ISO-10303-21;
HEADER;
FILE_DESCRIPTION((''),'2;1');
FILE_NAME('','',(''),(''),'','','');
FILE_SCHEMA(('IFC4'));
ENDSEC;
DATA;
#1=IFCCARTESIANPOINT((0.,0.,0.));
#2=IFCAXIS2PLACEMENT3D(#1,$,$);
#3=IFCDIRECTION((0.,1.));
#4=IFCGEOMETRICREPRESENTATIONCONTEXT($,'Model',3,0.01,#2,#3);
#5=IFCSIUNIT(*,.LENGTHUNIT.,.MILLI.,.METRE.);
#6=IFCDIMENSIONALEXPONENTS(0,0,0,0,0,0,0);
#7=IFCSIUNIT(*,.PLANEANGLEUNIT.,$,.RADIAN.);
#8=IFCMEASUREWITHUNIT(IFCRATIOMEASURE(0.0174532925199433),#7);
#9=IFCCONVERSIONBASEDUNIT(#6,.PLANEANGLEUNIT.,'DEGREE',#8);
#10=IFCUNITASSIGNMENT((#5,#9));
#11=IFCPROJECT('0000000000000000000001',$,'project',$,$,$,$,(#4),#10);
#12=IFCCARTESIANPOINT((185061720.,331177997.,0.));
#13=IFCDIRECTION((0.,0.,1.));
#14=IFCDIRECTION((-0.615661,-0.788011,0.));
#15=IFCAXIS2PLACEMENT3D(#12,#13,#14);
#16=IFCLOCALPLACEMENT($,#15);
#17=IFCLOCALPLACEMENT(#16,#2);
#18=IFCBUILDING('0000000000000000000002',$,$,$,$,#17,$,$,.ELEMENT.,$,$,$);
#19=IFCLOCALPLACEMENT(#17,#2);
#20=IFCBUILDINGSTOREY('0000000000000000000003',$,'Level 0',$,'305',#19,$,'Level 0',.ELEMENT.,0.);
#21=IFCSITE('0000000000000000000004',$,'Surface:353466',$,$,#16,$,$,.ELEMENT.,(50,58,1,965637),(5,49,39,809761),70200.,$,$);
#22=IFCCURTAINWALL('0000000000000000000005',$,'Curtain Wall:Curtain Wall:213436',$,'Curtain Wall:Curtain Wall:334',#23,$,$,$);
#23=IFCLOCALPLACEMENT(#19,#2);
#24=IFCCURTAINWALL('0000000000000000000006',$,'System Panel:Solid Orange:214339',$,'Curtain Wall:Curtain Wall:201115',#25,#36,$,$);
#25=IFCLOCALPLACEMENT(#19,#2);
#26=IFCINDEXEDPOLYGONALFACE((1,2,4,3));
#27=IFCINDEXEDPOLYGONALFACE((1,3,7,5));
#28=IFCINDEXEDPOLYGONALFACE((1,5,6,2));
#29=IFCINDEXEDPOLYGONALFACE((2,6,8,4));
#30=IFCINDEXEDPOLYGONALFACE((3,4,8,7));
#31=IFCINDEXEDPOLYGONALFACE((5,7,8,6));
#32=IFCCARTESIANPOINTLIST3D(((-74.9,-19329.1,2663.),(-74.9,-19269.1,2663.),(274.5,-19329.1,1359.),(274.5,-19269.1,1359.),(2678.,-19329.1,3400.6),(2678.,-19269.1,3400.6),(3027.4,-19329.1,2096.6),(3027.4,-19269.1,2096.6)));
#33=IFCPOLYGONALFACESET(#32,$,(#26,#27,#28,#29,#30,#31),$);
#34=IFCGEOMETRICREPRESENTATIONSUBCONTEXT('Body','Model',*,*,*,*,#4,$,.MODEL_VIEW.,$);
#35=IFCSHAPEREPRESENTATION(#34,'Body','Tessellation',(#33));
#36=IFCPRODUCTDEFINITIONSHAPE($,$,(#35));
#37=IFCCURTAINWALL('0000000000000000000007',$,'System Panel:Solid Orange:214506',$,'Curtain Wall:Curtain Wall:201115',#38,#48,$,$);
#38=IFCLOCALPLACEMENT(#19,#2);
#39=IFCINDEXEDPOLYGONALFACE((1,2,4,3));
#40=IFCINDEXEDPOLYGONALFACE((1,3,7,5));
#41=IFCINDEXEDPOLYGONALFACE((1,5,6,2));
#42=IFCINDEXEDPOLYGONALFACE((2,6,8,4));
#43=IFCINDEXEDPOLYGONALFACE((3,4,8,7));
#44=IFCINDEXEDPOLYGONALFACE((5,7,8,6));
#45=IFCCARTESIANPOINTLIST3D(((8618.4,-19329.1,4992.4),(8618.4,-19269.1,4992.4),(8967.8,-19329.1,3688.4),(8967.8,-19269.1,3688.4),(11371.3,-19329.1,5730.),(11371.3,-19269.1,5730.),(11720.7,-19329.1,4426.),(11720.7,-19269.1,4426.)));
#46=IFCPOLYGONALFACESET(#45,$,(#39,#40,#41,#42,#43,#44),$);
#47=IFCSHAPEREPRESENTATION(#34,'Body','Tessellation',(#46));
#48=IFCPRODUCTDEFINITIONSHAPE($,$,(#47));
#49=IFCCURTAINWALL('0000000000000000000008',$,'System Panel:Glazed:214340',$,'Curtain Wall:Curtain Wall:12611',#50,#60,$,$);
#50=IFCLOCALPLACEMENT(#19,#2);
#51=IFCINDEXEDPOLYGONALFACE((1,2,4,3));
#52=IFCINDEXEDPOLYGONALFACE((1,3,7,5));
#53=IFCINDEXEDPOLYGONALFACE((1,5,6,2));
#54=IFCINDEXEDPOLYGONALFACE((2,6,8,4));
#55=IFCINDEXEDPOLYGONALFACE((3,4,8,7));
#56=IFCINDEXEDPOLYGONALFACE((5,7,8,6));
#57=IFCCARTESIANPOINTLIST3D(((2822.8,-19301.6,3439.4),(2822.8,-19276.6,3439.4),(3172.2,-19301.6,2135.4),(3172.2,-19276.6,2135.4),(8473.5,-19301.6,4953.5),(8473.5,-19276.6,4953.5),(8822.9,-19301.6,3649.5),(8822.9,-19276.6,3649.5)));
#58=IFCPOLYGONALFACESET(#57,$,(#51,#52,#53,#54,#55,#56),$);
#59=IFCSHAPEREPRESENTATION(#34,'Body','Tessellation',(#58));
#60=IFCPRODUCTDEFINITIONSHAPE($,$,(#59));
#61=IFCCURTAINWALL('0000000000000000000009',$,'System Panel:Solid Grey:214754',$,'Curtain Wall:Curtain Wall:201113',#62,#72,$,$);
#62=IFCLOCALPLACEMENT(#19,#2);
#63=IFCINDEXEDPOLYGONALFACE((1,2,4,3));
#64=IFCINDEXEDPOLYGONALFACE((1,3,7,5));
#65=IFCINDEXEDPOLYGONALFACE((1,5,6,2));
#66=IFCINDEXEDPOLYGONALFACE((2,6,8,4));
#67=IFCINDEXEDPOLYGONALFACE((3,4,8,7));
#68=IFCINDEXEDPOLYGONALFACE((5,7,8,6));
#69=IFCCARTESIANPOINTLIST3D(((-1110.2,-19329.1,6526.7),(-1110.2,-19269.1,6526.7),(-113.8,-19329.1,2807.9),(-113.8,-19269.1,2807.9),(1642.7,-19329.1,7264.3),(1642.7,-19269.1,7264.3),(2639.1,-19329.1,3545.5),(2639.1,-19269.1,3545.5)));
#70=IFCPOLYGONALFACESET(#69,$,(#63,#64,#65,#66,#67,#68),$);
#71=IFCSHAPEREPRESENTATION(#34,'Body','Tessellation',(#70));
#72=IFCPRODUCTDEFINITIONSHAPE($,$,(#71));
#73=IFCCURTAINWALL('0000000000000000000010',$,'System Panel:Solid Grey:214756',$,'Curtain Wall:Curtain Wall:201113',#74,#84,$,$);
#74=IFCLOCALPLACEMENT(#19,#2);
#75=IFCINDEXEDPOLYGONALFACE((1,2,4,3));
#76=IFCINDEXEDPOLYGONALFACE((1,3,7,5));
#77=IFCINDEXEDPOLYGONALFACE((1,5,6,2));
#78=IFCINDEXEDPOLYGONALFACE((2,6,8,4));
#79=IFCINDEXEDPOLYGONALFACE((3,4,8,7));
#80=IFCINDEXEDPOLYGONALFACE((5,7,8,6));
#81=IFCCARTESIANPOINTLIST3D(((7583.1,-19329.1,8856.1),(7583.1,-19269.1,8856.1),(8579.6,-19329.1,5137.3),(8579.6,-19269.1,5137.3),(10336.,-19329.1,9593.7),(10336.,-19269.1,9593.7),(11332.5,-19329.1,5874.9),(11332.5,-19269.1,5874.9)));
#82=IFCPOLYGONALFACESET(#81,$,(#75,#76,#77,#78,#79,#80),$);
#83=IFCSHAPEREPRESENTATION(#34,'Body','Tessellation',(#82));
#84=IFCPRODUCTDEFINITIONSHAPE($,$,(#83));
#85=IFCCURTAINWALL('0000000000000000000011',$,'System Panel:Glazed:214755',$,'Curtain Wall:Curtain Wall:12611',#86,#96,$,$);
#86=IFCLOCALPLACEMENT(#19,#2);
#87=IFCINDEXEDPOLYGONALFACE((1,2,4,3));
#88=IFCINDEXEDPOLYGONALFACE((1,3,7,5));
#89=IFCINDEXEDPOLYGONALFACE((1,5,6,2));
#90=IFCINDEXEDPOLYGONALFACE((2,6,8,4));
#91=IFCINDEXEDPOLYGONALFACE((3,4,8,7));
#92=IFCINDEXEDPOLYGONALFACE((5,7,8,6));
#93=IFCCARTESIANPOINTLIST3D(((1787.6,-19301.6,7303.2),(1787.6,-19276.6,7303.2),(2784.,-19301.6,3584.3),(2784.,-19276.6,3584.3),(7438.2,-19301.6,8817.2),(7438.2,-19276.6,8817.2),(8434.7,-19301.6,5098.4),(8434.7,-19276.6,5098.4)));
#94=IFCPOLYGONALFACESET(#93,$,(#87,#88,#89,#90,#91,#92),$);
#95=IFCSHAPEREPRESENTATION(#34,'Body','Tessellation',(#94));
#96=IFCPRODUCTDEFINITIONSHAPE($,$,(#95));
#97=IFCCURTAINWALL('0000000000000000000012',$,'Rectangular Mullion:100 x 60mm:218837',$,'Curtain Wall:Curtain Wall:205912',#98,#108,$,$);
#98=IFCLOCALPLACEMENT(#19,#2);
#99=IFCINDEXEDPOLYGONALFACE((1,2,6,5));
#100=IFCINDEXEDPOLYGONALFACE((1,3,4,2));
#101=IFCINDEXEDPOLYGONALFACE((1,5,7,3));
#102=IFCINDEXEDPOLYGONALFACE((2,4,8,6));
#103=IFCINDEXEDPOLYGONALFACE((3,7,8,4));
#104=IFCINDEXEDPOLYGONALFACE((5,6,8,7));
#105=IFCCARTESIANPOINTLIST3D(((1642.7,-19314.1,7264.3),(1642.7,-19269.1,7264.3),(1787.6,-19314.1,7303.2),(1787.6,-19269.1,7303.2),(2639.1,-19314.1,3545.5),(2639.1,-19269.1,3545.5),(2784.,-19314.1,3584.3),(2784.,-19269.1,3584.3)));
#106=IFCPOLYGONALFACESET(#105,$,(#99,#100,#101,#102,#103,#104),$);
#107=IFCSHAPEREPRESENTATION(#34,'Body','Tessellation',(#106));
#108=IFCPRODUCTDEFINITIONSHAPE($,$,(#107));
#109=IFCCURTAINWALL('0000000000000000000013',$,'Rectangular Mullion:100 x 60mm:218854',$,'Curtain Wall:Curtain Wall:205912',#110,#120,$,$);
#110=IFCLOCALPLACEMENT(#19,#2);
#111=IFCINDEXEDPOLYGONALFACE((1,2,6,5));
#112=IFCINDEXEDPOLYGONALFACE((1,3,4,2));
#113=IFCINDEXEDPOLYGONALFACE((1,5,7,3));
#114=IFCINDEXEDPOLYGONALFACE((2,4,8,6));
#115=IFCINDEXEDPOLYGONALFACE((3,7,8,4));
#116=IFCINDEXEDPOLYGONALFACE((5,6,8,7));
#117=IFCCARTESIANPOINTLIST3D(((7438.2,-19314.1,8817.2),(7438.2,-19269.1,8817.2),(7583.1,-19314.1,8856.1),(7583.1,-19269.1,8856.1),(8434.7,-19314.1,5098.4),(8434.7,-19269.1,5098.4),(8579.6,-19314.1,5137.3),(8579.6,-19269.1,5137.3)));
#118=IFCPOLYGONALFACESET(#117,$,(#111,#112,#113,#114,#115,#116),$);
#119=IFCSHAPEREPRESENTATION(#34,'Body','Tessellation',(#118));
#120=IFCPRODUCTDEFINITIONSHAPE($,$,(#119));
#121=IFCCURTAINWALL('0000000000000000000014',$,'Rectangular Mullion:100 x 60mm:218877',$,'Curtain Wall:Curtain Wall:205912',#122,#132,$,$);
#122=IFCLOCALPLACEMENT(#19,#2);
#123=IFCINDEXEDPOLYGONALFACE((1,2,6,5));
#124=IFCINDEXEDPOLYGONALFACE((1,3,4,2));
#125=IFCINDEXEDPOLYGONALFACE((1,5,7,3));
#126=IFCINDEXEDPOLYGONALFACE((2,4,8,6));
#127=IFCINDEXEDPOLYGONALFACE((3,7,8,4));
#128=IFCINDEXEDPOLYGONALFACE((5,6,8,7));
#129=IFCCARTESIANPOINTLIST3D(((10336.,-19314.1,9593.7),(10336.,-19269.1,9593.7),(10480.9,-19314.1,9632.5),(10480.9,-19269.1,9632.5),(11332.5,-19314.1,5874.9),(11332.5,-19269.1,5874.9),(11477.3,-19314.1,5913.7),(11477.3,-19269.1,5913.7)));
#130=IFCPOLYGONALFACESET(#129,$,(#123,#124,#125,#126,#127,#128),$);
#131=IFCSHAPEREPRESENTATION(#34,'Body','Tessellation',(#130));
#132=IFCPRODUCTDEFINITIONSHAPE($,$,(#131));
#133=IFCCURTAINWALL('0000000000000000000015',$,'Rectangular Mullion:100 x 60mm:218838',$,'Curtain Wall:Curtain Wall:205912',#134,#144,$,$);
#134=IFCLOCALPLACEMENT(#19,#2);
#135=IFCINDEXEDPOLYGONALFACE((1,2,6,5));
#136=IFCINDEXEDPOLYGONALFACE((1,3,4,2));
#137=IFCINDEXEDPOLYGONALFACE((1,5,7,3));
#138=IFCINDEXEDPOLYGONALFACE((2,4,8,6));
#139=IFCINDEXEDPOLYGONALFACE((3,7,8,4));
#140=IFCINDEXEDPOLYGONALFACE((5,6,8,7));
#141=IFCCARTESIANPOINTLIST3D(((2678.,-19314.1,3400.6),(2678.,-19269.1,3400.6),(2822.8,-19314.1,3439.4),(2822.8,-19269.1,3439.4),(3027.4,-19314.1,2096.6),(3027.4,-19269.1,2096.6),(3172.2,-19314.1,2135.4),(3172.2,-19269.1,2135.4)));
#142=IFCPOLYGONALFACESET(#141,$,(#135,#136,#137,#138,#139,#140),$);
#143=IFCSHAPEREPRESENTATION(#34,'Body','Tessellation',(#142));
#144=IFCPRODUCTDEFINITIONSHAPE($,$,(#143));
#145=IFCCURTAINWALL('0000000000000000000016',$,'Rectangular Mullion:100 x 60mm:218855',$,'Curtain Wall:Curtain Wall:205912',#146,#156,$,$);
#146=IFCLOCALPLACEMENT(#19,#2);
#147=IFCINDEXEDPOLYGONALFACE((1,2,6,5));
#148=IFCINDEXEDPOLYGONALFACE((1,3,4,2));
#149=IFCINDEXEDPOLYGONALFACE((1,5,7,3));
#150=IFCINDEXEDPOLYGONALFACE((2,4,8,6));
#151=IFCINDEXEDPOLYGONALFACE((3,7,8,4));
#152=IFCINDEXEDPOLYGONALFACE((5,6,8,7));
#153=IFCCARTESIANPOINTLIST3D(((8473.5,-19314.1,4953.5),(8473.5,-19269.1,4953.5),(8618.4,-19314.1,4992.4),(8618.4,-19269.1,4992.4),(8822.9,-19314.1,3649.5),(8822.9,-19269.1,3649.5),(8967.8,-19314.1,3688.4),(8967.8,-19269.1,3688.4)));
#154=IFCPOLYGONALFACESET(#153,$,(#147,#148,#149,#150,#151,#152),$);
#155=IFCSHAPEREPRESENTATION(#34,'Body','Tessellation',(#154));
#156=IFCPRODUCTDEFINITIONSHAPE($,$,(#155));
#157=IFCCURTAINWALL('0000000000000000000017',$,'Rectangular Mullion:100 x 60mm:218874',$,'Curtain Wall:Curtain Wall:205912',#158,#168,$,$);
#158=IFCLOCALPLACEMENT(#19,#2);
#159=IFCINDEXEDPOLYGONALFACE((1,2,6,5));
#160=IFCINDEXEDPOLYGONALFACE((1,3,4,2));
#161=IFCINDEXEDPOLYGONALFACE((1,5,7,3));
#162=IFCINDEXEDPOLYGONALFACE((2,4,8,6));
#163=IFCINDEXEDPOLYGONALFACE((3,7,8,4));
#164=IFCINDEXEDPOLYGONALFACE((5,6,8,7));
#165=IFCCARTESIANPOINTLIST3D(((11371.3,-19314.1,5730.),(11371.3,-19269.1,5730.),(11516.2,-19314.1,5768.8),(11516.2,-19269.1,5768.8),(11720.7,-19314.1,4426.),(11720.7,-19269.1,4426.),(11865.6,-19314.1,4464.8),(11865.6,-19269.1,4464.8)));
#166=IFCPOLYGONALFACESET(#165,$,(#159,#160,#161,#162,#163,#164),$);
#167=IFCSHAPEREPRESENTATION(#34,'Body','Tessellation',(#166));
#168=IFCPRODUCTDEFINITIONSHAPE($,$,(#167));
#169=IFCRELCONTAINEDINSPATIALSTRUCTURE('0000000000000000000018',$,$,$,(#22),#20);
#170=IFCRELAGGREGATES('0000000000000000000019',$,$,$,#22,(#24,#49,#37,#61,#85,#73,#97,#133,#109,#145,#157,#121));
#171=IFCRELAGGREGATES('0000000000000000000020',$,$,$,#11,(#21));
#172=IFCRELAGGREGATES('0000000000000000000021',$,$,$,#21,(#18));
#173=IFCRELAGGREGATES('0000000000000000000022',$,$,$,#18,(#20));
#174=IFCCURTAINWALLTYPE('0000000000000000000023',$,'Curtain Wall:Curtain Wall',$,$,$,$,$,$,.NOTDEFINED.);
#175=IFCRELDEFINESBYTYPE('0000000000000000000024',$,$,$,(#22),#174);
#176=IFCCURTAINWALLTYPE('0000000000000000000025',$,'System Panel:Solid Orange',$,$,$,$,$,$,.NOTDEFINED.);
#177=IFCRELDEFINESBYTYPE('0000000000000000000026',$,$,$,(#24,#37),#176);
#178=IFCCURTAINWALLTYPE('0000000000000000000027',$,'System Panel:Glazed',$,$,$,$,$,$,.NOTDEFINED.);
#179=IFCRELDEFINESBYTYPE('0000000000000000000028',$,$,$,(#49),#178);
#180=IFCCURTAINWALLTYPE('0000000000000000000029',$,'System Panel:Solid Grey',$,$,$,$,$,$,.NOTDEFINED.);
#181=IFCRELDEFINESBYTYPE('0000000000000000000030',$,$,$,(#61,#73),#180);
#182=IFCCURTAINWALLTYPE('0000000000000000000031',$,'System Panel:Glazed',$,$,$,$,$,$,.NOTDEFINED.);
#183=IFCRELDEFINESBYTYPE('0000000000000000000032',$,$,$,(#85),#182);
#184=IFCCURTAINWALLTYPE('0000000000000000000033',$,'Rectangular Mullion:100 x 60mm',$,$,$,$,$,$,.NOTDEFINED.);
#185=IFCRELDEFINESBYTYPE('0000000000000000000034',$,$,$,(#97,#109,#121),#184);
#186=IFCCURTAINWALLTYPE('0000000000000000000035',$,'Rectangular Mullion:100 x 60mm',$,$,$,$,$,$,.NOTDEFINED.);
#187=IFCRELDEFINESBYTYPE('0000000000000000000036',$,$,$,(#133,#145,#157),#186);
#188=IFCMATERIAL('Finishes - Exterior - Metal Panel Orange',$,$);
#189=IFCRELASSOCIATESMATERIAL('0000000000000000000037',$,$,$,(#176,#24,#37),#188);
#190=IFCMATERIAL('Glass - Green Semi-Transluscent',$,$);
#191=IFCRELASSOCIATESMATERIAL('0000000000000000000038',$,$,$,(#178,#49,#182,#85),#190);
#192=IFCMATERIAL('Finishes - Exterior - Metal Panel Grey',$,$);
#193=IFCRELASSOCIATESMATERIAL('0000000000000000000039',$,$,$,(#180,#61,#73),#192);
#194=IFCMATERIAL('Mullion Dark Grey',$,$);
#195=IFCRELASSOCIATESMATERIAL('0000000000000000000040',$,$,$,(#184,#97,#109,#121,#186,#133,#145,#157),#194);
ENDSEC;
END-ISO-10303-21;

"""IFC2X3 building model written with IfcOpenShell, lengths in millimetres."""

from ifc_helpers import new_model, entity, si_unit, converted_unit, direction, frame, frame_2d, origin, origin_2d_with_axis, place, context, subcontext, project, spatial, rectangle, extrude, source, transform, mapped, material, type_object, type_shapes, element, aggregate, save


model = new_model("IFC2X3")

# Units and contexts
model_context = context("Model", 3, precision=0.01, world=origin(), true_north=direction((0.0, 1.0)))
body_context = subcontext(model_context, "Body", "Model", "MODEL_VIEW")
ifc_project = project(units=[si_unit("LENGTHUNIT", "METRE", prefix="MILLI"), converted_unit("PLANEANGLEUNIT", "DEGREE", entity("IfcRatioMeasure", 0.0174532925199433), si_unit("PLANEANGLEUNIT", "RADIAN"), dimensions=[0, 0, 0, 0, 0, 0, 0])], contexts=[model_context])

# Site, building, storey
site_placement = place(None, frame((185061720.0, 331177997.0, 0.0), z_axis=(0.0, 0.0, 1.0), x_axis=(-0.615661, -0.788011, 0.0)))
site = spatial("IfcSite", under=ifc_project, at=site_placement, Name="Surface:353466", CompositionType="ELEMENT", RefLatitude=(50, 58, 1, 965637), RefLongitude=(5, 49, 39, 809761), RefElevation=70200.0)
building_placement = place(site_placement, origin())
building = spatial("IfcBuilding", under=site, at=building_placement, CompositionType="ELEMENT")
storey_placement = place(building_placement, origin())
storey = spatial("IfcBuildingStorey", under=building, at=storey_placement, Name="Level 0", ObjectType="305", LongName="Level 0", CompositionType="ELEMENT", Elevation=0.0)

# Curtain walls
curtain_wall_type_1 = type_object("IfcCurtainWallType", Name="Curtain Wall:Curtain Wall", PredefinedType="NOTDEFINED")
curtain_wall_1_placement = place(storey_placement, origin())
curtain_wall_1 = element("IfcCurtainWall", 1, at=curtain_wall_1_placement, inside=storey, type_object=curtain_wall_type_1, Name="Curtain Wall:Curtain Wall:213436", ObjectType="Curtain Wall:Curtain Wall:334")
ifc_material_1 = material(Name="Finishes - Exterior - Metal Panel Grey")
ifc_material_2 = material(Name="Finishes - Exterior - Metal Panel Orange")
curtain_wall_type_2 = type_object("IfcCurtainWallType", Name="System Panel:Solid Orange", PredefinedType="NOTDEFINED", material=ifc_material_2)
shared_shape_1 = source(origin(), body_context, "Body", "SweptSolid", [
    extrude(rectangle(XDim=60.0, YDim=2850.0, at=frame_2d((0.0, 0.0), x_axis=(1.0, 0.0))), frame((0.0, 0.0, 0.0), z_axis=(0.0, 0.0, 1.0), x_axis=(0.0, 1.0, 0.0)), (0.0, 0.0, 1.0), 1350.0),
])
type_shapes(curtain_wall_type_2, [shared_shape_1])
curtain_wall_2_placement = place(storey_placement, frame((1650.9, -19299.1, 1727.8), z_axis=(-0.258819, 0.0, 0.965926), x_axis=(0.965926, 0.0, 0.258819)))
curtain_wall_2 = element("IfcCurtainWall", 2, at=curtain_wall_2_placement, type_object=curtain_wall_type_2, material=ifc_material_2, Name="System Panel:Solid Orange:214339", ObjectType="Curtain Wall:Curtain Wall:201115", context=body_context, shape_type="MappedRepresentation", body=[
    mapped(shared_shape_1, transform((0.0, 0.0, 0.0), scale=1.0)),
])
curtain_wall_3_placement = place(storey_placement, frame((10344.2, -19299.1, 4057.2), z_axis=(-0.258819, 0.0, 0.965926), x_axis=(0.965926, 0.0, 0.258819)))
curtain_wall_3 = element("IfcCurtainWall", 3, at=curtain_wall_3_placement, type_object=curtain_wall_type_2, material=ifc_material_2, Name="System Panel:Solid Orange:214506", ObjectType="Curtain Wall:Curtain Wall:201115", context=body_context, shape_type="MappedRepresentation", body=[
    mapped(shared_shape_1, transform((0.0, 0.0, 0.0), scale=1.0)),
])
ifc_material_3 = material(Name="Glass - Green Semi-Transluscent")
curtain_wall_type_3 = type_object("IfcCurtainWallType", Name="System Panel:Glazed", PredefinedType="NOTDEFINED", material=ifc_material_3)
shared_shape_2 = source(origin(), body_context, "Body", "SweptSolid", [
    extrude(rectangle(XDim=25.0, YDim=5850.0, at=origin_2d_with_axis()), frame((0.0, 10.0, 0.0), z_axis=(0.0, 0.0, 1.0), x_axis=(0.0, 1.0, 0.0)), (0.0, 0.0, 1.0), 1350.0),
])
type_shapes(curtain_wall_type_3, [shared_shape_2])
curtain_wall_4_placement = place(storey_placement, frame((5997.6, -19299.1, 2892.5), z_axis=(-0.258819, 0.0, 0.965926), x_axis=(0.965926, 0.0, 0.258819)))
curtain_wall_4 = element("IfcCurtainWall", 4, at=curtain_wall_4_placement, type_object=curtain_wall_type_3, material=ifc_material_3, Name="System Panel:Glazed:214340", ObjectType="Curtain Wall:Curtain Wall:12611", context=body_context, shape_type="MappedRepresentation", body=[
    mapped(shared_shape_2, transform((0.0, 0.0, 0.0), scale=1.0)),
])
curtain_wall_type_4 = type_object("IfcCurtainWallType", Name="System Panel:Solid Grey", PredefinedType="NOTDEFINED", material=ifc_material_1)
shared_shape_3 = source(origin(), body_context, "Body", "SweptSolid", [
    extrude(rectangle(XDim=60.0, YDim=2850.0, at=origin_2d_with_axis()), frame((0.0, 0.0, 0.0), z_axis=(0.0, 0.0, 1.0), x_axis=(0.0, 1.0, 0.0)), (0.0, 0.0, 1.0), 3850.0),
])
type_shapes(curtain_wall_type_4, [shared_shape_3])
curtain_wall_5_placement = place(storey_placement, frame((1262.7, -19299.1, 3176.7), z_axis=(-0.258819, 0.0, 0.965926), x_axis=(0.965926, 0.0, 0.258819)))
curtain_wall_5 = element("IfcCurtainWall", 5, at=curtain_wall_5_placement, type_object=curtain_wall_type_4, material=ifc_material_1, Name="System Panel:Solid Grey:214754", ObjectType="Curtain Wall:Curtain Wall:201113", context=body_context, shape_type="MappedRepresentation", body=[
    mapped(shared_shape_3, transform((0.0, 0.0, 0.0), scale=1.0)),
])
curtain_wall_6_placement = place(storey_placement, frame((9956.0, -19299.1, 5506.1), z_axis=(-0.258819, 0.0, 0.965926), x_axis=(0.965926, 0.0, 0.258819)))
curtain_wall_6 = element("IfcCurtainWall", 6, at=curtain_wall_6_placement, type_object=curtain_wall_type_4, material=ifc_material_1, Name="System Panel:Solid Grey:214756", ObjectType="Curtain Wall:Curtain Wall:201113", context=body_context, shape_type="MappedRepresentation", body=[
    mapped(shared_shape_3, transform((0.0, 0.0, 0.0), scale=1.0)),
])
curtain_wall_type_5 = type_object("IfcCurtainWallType", Name="System Panel:Glazed", PredefinedType="NOTDEFINED", material=ifc_material_3)
shared_shape_4 = source(origin(), body_context, "Body", "SweptSolid", [
    extrude(rectangle(XDim=25.0, YDim=5850.0, at=origin_2d_with_axis()), frame((0.0, 10.0, 0.0), z_axis=(0.0, 0.0, 1.0), x_axis=(0.0, 1.0, 0.0)), (0.0, 0.0, 1.0), 3850.0),
])
type_shapes(curtain_wall_type_5, [shared_shape_4])
curtain_wall_7_placement = place(storey_placement, frame((5609.3, -19299.1, 4341.4), z_axis=(-0.258819, 0.0, 0.965926), x_axis=(0.965926, 0.0, 0.258819)))
curtain_wall_7 = element("IfcCurtainWall", 7, at=curtain_wall_7_placement, type_object=curtain_wall_type_5, material=ifc_material_3, Name="System Panel:Glazed:214755", ObjectType="Curtain Wall:Curtain Wall:12611", context=body_context, shape_type="MappedRepresentation", body=[
    mapped(shared_shape_4, transform((0.0, 0.0, 0.0), scale=1.0)),
])
ifc_material_4 = material(Name="Mullion Dark Grey")
curtain_wall_type_6 = type_object("IfcCurtainWallType", Name="Rectangular Mullion:100 x 60mm", PredefinedType="NOTDEFINED", material=ifc_material_4)
shared_shape_5 = source(origin(), body_context, "Body", "SweptSolid", [
    extrude(rectangle(XDim=150.0, YDim=45.0, at=frame_2d((0.0, 0.0), x_axis=(1.0, 0.0))), frame((0.0, -7.5, -3850.0)), (0.0, 0.0, 1.0), 3850.0),
])
type_shapes(curtain_wall_type_6, [shared_shape_5])
curtain_wall_8_placement = place(storey_placement, frame((2711.6, -19299.1, 3564.9), z_axis=(0.258819, 0.0, -0.965926), x_axis=(0.965926, 0.0, 0.258819)))
curtain_wall_8 = element("IfcCurtainWall", 8, at=curtain_wall_8_placement, type_object=curtain_wall_type_6, material=ifc_material_4, Name="Rectangular Mullion:100 x 60mm:218837", ObjectType="Curtain Wall:Curtain Wall:205912", context=body_context, shape_type="MappedRepresentation", body=[
    mapped(shared_shape_5, transform((0.0, 0.0, 0.0), scale=1.0)),
])
curtain_wall_9_placement = place(storey_placement, frame((8507.1, -19299.1, 5117.8), z_axis=(0.258819, 0.0, -0.965926), x_axis=(0.965926, 0.0, 0.258819)))
curtain_wall_9 = element("IfcCurtainWall", 9, at=curtain_wall_9_placement, type_object=curtain_wall_type_6, material=ifc_material_4, Name="Rectangular Mullion:100 x 60mm:218854", ObjectType="Curtain Wall:Curtain Wall:205912", context=body_context, shape_type="MappedRepresentation", body=[
    mapped(shared_shape_5, transform((0.0, 0.0, 0.0), scale=1.0)),
])
curtain_wall_10_placement = place(storey_placement, frame((11404.9, -19299.1, 5894.3), z_axis=(0.258819, 0.0, -0.965926), x_axis=(0.965926, 0.0, 0.258819)))
curtain_wall_10 = element("IfcCurtainWall", 10, at=curtain_wall_10_placement, type_object=curtain_wall_type_6, material=ifc_material_4, Name="Rectangular Mullion:100 x 60mm:218877", ObjectType="Curtain Wall:Curtain Wall:205912", context=body_context, shape_type="MappedRepresentation", body=[
    mapped(shared_shape_5, transform((0.0, 0.0, 0.0), scale=1.0)),
])
curtain_wall_type_7 = type_object("IfcCurtainWallType", Name="Rectangular Mullion:100 x 60mm", PredefinedType="NOTDEFINED", material=ifc_material_4)
shared_shape_6 = source(origin(), body_context, "Body", "SweptSolid", [
    extrude(rectangle(XDim=150.0, YDim=45.0, at=frame_2d((0.0, 0.0), x_axis=(1.0, 0.0))), frame((0.0, -7.5, -1350.0)), (0.0, 0.0, 1.0), 1350.0),
])
type_shapes(curtain_wall_type_7, [shared_shape_6])
curtain_wall_11_placement = place(storey_placement, frame((3099.8, -19299.1, 2116.0), z_axis=(0.258819, 0.0, -0.965926), x_axis=(0.965926, 0.0, 0.258819)))
curtain_wall_11 = element("IfcCurtainWall", 11, at=curtain_wall_11_placement, type_object=curtain_wall_type_7, material=ifc_material_4, Name="Rectangular Mullion:100 x 60mm:218838", ObjectType="Curtain Wall:Curtain Wall:205912", context=body_context, shape_type="MappedRepresentation", body=[
    mapped(shared_shape_6, transform((0.0, 0.0, 0.0), scale=1.0)),
])
curtain_wall_12_placement = place(storey_placement, frame((8895.4, -19299.1, 3669.0), z_axis=(0.258819, 0.0, -0.965926), x_axis=(0.965926, 0.0, 0.258819)))
curtain_wall_12 = element("IfcCurtainWall", 12, at=curtain_wall_12_placement, type_object=curtain_wall_type_7, material=ifc_material_4, Name="Rectangular Mullion:100 x 60mm:218855", ObjectType="Curtain Wall:Curtain Wall:205912", context=body_context, shape_type="MappedRepresentation", body=[
    mapped(shared_shape_6, transform((0.0, 0.0, 0.0), scale=1.0)),
])
curtain_wall_13_placement = place(storey_placement, frame((11793.1, -19299.1, 4445.4), z_axis=(0.258819, 0.0, -0.965926), x_axis=(0.965926, 0.0, 0.258819)))
curtain_wall_13 = element("IfcCurtainWall", 13, at=curtain_wall_13_placement, type_object=curtain_wall_type_7, material=ifc_material_4, Name="Rectangular Mullion:100 x 60mm:218874", ObjectType="Curtain Wall:Curtain Wall:205912", context=body_context, shape_type="MappedRepresentation", body=[
    mapped(shared_shape_6, transform((0.0, 0.0, 0.0), scale=1.0)),
])
aggregate(curtain_wall_1, [curtain_wall_2, curtain_wall_4, curtain_wall_3, curtain_wall_5, curtain_wall_7, curtain_wall_6, curtain_wall_8, curtain_wall_11, curtain_wall_9, curtain_wall_12, curtain_wall_13, curtain_wall_10])

save(model, "model.ifc")
